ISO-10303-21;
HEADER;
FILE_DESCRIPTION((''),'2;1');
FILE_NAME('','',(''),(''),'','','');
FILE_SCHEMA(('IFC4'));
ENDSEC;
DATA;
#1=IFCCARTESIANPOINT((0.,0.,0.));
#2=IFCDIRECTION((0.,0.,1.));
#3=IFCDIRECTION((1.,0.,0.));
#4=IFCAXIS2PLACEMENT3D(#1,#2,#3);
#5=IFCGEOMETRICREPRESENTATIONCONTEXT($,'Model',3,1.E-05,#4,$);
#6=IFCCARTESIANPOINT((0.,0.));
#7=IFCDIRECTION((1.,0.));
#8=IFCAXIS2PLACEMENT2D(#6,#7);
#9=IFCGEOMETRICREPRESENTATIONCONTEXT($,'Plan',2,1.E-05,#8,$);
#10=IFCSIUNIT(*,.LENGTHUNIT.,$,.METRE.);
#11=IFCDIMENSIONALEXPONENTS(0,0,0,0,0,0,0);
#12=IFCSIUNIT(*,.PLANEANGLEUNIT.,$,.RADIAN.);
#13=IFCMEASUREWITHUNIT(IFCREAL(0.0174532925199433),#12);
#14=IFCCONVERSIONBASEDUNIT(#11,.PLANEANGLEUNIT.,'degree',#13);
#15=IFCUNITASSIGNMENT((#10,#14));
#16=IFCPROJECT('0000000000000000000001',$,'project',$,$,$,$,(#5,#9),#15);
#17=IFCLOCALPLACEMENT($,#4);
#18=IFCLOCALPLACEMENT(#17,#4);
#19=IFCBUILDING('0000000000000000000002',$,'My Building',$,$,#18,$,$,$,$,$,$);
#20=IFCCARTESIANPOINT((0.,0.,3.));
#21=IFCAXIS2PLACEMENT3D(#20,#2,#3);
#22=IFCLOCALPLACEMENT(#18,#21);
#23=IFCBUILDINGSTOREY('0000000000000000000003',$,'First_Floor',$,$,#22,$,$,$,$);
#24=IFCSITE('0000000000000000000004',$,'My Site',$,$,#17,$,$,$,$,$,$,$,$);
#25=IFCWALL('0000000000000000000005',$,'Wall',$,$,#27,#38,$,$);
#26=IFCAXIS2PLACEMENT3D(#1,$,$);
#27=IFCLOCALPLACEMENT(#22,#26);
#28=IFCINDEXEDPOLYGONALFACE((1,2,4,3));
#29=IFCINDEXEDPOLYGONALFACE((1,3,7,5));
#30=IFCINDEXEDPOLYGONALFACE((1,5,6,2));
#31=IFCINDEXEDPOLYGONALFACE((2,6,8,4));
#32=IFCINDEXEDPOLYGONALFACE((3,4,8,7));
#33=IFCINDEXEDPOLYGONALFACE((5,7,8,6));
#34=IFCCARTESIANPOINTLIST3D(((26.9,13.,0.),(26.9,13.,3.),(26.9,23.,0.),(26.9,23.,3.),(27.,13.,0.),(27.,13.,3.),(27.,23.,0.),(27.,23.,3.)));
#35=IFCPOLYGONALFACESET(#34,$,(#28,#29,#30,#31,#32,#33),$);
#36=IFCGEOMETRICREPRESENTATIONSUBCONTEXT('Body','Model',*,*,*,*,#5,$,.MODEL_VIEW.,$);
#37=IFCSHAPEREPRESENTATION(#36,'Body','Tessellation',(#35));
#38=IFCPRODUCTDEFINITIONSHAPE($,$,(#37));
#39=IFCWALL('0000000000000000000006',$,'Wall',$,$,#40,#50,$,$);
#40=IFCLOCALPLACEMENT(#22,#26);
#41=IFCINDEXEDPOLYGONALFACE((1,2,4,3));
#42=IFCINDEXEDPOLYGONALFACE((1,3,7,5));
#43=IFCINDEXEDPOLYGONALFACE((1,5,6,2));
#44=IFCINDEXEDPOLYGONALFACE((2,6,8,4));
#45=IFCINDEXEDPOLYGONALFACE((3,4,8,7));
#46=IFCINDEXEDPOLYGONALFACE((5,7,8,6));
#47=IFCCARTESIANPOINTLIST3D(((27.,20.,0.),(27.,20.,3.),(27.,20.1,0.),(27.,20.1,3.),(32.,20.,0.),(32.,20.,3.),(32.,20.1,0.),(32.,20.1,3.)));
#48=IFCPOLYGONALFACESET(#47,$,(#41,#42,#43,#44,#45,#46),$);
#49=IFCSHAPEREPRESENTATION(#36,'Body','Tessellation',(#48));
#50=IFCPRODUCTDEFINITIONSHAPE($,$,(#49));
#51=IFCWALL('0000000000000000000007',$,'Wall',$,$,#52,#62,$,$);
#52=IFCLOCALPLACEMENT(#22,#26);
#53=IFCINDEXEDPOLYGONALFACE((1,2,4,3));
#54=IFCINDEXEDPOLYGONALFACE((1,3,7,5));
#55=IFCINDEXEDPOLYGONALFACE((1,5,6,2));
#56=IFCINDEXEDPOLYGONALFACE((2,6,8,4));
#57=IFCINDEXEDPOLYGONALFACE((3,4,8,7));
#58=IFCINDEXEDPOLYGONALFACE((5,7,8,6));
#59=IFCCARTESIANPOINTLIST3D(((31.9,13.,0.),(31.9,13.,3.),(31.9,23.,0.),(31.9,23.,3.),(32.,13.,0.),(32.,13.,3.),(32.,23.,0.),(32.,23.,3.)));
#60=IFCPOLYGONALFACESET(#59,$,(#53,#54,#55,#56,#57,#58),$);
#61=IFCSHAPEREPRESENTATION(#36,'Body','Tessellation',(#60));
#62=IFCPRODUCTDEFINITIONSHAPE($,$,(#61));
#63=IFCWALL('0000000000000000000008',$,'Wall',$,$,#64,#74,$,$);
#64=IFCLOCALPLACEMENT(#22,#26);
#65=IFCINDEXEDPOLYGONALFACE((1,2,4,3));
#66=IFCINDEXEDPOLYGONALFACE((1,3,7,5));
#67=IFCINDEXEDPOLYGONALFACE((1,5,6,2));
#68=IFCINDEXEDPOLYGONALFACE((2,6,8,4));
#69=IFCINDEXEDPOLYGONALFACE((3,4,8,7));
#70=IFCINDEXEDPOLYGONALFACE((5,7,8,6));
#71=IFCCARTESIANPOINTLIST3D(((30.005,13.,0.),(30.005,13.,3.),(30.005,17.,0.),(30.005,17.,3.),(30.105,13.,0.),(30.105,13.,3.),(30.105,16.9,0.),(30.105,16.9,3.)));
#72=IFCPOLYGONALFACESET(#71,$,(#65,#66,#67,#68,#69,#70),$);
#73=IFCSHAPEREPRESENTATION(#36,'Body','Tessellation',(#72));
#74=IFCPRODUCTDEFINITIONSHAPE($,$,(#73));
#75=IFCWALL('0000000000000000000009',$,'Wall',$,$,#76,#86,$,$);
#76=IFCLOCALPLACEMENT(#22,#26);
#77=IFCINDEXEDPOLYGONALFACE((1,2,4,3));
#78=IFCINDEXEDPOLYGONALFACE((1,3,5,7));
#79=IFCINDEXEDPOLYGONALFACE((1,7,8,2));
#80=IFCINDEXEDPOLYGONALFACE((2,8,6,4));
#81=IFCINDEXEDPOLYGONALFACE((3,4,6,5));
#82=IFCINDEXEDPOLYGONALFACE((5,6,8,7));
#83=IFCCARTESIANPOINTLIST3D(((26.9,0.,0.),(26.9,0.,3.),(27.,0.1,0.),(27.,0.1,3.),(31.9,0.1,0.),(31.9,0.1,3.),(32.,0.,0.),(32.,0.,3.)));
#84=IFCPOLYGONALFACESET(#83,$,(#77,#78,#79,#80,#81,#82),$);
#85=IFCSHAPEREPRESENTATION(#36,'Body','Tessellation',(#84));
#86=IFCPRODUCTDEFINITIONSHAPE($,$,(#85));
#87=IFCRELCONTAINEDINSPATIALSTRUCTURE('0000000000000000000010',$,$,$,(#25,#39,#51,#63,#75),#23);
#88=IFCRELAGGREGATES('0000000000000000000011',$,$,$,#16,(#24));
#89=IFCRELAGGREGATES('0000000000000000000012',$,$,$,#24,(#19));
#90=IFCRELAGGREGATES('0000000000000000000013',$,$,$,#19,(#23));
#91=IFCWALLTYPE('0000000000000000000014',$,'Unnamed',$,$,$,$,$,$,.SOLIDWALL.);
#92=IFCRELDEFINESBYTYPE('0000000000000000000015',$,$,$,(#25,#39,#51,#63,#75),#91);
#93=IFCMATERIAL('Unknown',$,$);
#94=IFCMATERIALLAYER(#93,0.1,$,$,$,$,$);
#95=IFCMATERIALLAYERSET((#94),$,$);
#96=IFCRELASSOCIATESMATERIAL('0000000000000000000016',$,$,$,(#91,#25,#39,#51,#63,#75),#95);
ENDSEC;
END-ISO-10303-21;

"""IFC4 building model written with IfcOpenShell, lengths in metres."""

from ifc_helpers import new_model, entity, si_unit, converted_unit, frame, origin_with_axes, origin_2d_with_axis, place, context, subcontext, project, spatial, line, indexed_curve, outline, extrude, material, layer, layer_set, layer_usage, type_object, element, save


model = new_model("IFC4")

# Units and contexts
model_context = context("Model", 3, precision=1e-05, world=origin_with_axes())
plan_context = context("Plan", 2, precision=1e-05, world=origin_2d_with_axis())
body_context_1 = subcontext(model_context, "Body", "Model", "MODEL_VIEW")
ifc_project = project(units=[si_unit("LENGTHUNIT", "METRE"), converted_unit("PLANEANGLEUNIT", "degree", entity("IfcReal", 0.0174532925199433), si_unit("PLANEANGLEUNIT", "RADIAN"), dimensions=[0, 0, 0, 0, 0, 0, 0])], contexts=[model_context, plan_context])

# Site, building, storey
site_placement = place(None, origin_with_axes())
site = spatial("IfcSite", under=ifc_project, at=site_placement, Name="My Site")
building_placement = place(site_placement, origin_with_axes())
building = spatial("IfcBuilding", under=site, at=building_placement, Name="My Building")
storey_placement = place(building_placement, frame((0.0, 0.0, 3.0), z_axis=(0.0, 0.0, 1.0), x_axis=(1.0, 0.0, 0.0)))
storey = spatial("IfcBuildingStorey", under=building, at=storey_placement, Name="First_Floor")

# Shared definitions
ifc_material = material(Name="Unknown")
ifc_layer = layer(ifc_material, 0.1)
ifc_layer_set = layer_set([ifc_layer])
wall_type = type_object("IfcWallType", Name="Unnamed", PredefinedType="SOLIDWALL", material=ifc_layer_set)

# Walls
ifc_layer_usage_1 = layer_usage(ifc_layer_set, "AXIS2", "POSITIVE", 0.0)
wall_1_placement = place(storey_placement, frame((26.9, 23.0, 0.0), z_axis=(0.0, 0.0, 1.0), x_axis=(0.0, -1.0, 0.0)))
element("IfcWall", 1, at=wall_1_placement, inside=storey, type_object=wall_type, material=ifc_layer_usage_1, Name="Wall", context=body_context_1, shape_type="SweptSolid", body=[
    extrude(outline(indexed_curve([(0.0, 0.0), (0.0, 0.1), (10.0, 0.1), (10.0, 0.0)], segments=[line(1, 2, 3, 4, 1)])), origin_with_axes(), (0.0, 0.0, 1.0), 3.0),
])
ifc_layer_usage_2 = layer_usage(ifc_layer_set, "AXIS2", "POSITIVE", 0.0)
wall_2_placement = place(storey_placement, frame((27.0, 20.0, 0.0), z_axis=(0.0, 0.0, 1.0), x_axis=(1.0, 0.0, 0.0)))
element("IfcWall", 2, at=wall_2_placement, inside=storey, type_object=wall_type, material=ifc_layer_usage_2, Name="Wall", context=body_context_1, shape_type="SweptSolid", body=[
    extrude(outline(indexed_curve([(0.0, 0.0), (0.0, 0.1), (5.0, 0.1), (5.0, 0.0)], segments=[line(1, 2, 3, 4, 1)])), origin_with_axes(), (0.0, 0.0, 1.0), 3.0),
])
ifc_layer_usage_3 = layer_usage(ifc_layer_set, "AXIS2", "POSITIVE", 0.0)
wall_3_placement = place(storey_placement, frame((31.9, 23.0, 0.0), z_axis=(0.0, 0.0, 1.0), x_axis=(0.0, -1.0, 0.0)))
element("IfcWall", 3, at=wall_3_placement, inside=storey, type_object=wall_type, material=ifc_layer_usage_3, Name="Wall", context=body_context_1, shape_type="SweptSolid", body=[
    extrude(outline(indexed_curve([(0.0, 0.0), (0.0, 0.1), (10.0, 0.1), (10.0, 0.0)], segments=[line(1, 2, 3, 4, 1)])), origin_with_axes(), (0.0, 0.0, 1.0), 3.0),
])
ifc_layer_usage_4 = layer_usage(ifc_layer_set, "AXIS2", "POSITIVE", 0.0)
wall_4_placement = place(storey_placement, frame((30.005, 17.0, 0.0), z_axis=(0.0, 0.0, 1.0), x_axis=(0.0, -1.0, 0.0)))
element("IfcWall", 4, at=wall_4_placement, inside=storey, type_object=wall_type, material=ifc_layer_usage_4, Name="Wall", context=body_context_1, shape_type="SweptSolid", body=[
    extrude(outline(indexed_curve([(0.0, 0.0), (0.1, 0.1), (4.0, 0.1), (4.0, 0.0)], segments=[line(1, 2, 3, 4, 1)])), origin_with_axes(), (0.0, 0.0, 1.0), 3.0),
])
ifc_layer_usage_5 = layer_usage(ifc_layer_set, "AXIS2", "POSITIVE", 0.0)
wall_5_placement = place(storey_placement, frame((26.9, 0.0, 0.0), z_axis=(0.0, 0.0, 1.0), x_axis=(1.0, 0.0, 0.0)))
element("IfcWall", 5, at=wall_5_placement, inside=storey, type_object=wall_type, material=ifc_layer_usage_5, Name="Wall", context=body_context_1, shape_type="SweptSolid", body=[
    extrude(outline(indexed_curve([(0.0, 0.0), (0.1, 0.1), (5.0, 0.1), (5.1, 0.0)], segments=[line(1, 2, 3, 4, 1)])), origin_with_axes(), (0.0, 0.0, 1.0), 3.0),
])

save(model, "model.ifc")
